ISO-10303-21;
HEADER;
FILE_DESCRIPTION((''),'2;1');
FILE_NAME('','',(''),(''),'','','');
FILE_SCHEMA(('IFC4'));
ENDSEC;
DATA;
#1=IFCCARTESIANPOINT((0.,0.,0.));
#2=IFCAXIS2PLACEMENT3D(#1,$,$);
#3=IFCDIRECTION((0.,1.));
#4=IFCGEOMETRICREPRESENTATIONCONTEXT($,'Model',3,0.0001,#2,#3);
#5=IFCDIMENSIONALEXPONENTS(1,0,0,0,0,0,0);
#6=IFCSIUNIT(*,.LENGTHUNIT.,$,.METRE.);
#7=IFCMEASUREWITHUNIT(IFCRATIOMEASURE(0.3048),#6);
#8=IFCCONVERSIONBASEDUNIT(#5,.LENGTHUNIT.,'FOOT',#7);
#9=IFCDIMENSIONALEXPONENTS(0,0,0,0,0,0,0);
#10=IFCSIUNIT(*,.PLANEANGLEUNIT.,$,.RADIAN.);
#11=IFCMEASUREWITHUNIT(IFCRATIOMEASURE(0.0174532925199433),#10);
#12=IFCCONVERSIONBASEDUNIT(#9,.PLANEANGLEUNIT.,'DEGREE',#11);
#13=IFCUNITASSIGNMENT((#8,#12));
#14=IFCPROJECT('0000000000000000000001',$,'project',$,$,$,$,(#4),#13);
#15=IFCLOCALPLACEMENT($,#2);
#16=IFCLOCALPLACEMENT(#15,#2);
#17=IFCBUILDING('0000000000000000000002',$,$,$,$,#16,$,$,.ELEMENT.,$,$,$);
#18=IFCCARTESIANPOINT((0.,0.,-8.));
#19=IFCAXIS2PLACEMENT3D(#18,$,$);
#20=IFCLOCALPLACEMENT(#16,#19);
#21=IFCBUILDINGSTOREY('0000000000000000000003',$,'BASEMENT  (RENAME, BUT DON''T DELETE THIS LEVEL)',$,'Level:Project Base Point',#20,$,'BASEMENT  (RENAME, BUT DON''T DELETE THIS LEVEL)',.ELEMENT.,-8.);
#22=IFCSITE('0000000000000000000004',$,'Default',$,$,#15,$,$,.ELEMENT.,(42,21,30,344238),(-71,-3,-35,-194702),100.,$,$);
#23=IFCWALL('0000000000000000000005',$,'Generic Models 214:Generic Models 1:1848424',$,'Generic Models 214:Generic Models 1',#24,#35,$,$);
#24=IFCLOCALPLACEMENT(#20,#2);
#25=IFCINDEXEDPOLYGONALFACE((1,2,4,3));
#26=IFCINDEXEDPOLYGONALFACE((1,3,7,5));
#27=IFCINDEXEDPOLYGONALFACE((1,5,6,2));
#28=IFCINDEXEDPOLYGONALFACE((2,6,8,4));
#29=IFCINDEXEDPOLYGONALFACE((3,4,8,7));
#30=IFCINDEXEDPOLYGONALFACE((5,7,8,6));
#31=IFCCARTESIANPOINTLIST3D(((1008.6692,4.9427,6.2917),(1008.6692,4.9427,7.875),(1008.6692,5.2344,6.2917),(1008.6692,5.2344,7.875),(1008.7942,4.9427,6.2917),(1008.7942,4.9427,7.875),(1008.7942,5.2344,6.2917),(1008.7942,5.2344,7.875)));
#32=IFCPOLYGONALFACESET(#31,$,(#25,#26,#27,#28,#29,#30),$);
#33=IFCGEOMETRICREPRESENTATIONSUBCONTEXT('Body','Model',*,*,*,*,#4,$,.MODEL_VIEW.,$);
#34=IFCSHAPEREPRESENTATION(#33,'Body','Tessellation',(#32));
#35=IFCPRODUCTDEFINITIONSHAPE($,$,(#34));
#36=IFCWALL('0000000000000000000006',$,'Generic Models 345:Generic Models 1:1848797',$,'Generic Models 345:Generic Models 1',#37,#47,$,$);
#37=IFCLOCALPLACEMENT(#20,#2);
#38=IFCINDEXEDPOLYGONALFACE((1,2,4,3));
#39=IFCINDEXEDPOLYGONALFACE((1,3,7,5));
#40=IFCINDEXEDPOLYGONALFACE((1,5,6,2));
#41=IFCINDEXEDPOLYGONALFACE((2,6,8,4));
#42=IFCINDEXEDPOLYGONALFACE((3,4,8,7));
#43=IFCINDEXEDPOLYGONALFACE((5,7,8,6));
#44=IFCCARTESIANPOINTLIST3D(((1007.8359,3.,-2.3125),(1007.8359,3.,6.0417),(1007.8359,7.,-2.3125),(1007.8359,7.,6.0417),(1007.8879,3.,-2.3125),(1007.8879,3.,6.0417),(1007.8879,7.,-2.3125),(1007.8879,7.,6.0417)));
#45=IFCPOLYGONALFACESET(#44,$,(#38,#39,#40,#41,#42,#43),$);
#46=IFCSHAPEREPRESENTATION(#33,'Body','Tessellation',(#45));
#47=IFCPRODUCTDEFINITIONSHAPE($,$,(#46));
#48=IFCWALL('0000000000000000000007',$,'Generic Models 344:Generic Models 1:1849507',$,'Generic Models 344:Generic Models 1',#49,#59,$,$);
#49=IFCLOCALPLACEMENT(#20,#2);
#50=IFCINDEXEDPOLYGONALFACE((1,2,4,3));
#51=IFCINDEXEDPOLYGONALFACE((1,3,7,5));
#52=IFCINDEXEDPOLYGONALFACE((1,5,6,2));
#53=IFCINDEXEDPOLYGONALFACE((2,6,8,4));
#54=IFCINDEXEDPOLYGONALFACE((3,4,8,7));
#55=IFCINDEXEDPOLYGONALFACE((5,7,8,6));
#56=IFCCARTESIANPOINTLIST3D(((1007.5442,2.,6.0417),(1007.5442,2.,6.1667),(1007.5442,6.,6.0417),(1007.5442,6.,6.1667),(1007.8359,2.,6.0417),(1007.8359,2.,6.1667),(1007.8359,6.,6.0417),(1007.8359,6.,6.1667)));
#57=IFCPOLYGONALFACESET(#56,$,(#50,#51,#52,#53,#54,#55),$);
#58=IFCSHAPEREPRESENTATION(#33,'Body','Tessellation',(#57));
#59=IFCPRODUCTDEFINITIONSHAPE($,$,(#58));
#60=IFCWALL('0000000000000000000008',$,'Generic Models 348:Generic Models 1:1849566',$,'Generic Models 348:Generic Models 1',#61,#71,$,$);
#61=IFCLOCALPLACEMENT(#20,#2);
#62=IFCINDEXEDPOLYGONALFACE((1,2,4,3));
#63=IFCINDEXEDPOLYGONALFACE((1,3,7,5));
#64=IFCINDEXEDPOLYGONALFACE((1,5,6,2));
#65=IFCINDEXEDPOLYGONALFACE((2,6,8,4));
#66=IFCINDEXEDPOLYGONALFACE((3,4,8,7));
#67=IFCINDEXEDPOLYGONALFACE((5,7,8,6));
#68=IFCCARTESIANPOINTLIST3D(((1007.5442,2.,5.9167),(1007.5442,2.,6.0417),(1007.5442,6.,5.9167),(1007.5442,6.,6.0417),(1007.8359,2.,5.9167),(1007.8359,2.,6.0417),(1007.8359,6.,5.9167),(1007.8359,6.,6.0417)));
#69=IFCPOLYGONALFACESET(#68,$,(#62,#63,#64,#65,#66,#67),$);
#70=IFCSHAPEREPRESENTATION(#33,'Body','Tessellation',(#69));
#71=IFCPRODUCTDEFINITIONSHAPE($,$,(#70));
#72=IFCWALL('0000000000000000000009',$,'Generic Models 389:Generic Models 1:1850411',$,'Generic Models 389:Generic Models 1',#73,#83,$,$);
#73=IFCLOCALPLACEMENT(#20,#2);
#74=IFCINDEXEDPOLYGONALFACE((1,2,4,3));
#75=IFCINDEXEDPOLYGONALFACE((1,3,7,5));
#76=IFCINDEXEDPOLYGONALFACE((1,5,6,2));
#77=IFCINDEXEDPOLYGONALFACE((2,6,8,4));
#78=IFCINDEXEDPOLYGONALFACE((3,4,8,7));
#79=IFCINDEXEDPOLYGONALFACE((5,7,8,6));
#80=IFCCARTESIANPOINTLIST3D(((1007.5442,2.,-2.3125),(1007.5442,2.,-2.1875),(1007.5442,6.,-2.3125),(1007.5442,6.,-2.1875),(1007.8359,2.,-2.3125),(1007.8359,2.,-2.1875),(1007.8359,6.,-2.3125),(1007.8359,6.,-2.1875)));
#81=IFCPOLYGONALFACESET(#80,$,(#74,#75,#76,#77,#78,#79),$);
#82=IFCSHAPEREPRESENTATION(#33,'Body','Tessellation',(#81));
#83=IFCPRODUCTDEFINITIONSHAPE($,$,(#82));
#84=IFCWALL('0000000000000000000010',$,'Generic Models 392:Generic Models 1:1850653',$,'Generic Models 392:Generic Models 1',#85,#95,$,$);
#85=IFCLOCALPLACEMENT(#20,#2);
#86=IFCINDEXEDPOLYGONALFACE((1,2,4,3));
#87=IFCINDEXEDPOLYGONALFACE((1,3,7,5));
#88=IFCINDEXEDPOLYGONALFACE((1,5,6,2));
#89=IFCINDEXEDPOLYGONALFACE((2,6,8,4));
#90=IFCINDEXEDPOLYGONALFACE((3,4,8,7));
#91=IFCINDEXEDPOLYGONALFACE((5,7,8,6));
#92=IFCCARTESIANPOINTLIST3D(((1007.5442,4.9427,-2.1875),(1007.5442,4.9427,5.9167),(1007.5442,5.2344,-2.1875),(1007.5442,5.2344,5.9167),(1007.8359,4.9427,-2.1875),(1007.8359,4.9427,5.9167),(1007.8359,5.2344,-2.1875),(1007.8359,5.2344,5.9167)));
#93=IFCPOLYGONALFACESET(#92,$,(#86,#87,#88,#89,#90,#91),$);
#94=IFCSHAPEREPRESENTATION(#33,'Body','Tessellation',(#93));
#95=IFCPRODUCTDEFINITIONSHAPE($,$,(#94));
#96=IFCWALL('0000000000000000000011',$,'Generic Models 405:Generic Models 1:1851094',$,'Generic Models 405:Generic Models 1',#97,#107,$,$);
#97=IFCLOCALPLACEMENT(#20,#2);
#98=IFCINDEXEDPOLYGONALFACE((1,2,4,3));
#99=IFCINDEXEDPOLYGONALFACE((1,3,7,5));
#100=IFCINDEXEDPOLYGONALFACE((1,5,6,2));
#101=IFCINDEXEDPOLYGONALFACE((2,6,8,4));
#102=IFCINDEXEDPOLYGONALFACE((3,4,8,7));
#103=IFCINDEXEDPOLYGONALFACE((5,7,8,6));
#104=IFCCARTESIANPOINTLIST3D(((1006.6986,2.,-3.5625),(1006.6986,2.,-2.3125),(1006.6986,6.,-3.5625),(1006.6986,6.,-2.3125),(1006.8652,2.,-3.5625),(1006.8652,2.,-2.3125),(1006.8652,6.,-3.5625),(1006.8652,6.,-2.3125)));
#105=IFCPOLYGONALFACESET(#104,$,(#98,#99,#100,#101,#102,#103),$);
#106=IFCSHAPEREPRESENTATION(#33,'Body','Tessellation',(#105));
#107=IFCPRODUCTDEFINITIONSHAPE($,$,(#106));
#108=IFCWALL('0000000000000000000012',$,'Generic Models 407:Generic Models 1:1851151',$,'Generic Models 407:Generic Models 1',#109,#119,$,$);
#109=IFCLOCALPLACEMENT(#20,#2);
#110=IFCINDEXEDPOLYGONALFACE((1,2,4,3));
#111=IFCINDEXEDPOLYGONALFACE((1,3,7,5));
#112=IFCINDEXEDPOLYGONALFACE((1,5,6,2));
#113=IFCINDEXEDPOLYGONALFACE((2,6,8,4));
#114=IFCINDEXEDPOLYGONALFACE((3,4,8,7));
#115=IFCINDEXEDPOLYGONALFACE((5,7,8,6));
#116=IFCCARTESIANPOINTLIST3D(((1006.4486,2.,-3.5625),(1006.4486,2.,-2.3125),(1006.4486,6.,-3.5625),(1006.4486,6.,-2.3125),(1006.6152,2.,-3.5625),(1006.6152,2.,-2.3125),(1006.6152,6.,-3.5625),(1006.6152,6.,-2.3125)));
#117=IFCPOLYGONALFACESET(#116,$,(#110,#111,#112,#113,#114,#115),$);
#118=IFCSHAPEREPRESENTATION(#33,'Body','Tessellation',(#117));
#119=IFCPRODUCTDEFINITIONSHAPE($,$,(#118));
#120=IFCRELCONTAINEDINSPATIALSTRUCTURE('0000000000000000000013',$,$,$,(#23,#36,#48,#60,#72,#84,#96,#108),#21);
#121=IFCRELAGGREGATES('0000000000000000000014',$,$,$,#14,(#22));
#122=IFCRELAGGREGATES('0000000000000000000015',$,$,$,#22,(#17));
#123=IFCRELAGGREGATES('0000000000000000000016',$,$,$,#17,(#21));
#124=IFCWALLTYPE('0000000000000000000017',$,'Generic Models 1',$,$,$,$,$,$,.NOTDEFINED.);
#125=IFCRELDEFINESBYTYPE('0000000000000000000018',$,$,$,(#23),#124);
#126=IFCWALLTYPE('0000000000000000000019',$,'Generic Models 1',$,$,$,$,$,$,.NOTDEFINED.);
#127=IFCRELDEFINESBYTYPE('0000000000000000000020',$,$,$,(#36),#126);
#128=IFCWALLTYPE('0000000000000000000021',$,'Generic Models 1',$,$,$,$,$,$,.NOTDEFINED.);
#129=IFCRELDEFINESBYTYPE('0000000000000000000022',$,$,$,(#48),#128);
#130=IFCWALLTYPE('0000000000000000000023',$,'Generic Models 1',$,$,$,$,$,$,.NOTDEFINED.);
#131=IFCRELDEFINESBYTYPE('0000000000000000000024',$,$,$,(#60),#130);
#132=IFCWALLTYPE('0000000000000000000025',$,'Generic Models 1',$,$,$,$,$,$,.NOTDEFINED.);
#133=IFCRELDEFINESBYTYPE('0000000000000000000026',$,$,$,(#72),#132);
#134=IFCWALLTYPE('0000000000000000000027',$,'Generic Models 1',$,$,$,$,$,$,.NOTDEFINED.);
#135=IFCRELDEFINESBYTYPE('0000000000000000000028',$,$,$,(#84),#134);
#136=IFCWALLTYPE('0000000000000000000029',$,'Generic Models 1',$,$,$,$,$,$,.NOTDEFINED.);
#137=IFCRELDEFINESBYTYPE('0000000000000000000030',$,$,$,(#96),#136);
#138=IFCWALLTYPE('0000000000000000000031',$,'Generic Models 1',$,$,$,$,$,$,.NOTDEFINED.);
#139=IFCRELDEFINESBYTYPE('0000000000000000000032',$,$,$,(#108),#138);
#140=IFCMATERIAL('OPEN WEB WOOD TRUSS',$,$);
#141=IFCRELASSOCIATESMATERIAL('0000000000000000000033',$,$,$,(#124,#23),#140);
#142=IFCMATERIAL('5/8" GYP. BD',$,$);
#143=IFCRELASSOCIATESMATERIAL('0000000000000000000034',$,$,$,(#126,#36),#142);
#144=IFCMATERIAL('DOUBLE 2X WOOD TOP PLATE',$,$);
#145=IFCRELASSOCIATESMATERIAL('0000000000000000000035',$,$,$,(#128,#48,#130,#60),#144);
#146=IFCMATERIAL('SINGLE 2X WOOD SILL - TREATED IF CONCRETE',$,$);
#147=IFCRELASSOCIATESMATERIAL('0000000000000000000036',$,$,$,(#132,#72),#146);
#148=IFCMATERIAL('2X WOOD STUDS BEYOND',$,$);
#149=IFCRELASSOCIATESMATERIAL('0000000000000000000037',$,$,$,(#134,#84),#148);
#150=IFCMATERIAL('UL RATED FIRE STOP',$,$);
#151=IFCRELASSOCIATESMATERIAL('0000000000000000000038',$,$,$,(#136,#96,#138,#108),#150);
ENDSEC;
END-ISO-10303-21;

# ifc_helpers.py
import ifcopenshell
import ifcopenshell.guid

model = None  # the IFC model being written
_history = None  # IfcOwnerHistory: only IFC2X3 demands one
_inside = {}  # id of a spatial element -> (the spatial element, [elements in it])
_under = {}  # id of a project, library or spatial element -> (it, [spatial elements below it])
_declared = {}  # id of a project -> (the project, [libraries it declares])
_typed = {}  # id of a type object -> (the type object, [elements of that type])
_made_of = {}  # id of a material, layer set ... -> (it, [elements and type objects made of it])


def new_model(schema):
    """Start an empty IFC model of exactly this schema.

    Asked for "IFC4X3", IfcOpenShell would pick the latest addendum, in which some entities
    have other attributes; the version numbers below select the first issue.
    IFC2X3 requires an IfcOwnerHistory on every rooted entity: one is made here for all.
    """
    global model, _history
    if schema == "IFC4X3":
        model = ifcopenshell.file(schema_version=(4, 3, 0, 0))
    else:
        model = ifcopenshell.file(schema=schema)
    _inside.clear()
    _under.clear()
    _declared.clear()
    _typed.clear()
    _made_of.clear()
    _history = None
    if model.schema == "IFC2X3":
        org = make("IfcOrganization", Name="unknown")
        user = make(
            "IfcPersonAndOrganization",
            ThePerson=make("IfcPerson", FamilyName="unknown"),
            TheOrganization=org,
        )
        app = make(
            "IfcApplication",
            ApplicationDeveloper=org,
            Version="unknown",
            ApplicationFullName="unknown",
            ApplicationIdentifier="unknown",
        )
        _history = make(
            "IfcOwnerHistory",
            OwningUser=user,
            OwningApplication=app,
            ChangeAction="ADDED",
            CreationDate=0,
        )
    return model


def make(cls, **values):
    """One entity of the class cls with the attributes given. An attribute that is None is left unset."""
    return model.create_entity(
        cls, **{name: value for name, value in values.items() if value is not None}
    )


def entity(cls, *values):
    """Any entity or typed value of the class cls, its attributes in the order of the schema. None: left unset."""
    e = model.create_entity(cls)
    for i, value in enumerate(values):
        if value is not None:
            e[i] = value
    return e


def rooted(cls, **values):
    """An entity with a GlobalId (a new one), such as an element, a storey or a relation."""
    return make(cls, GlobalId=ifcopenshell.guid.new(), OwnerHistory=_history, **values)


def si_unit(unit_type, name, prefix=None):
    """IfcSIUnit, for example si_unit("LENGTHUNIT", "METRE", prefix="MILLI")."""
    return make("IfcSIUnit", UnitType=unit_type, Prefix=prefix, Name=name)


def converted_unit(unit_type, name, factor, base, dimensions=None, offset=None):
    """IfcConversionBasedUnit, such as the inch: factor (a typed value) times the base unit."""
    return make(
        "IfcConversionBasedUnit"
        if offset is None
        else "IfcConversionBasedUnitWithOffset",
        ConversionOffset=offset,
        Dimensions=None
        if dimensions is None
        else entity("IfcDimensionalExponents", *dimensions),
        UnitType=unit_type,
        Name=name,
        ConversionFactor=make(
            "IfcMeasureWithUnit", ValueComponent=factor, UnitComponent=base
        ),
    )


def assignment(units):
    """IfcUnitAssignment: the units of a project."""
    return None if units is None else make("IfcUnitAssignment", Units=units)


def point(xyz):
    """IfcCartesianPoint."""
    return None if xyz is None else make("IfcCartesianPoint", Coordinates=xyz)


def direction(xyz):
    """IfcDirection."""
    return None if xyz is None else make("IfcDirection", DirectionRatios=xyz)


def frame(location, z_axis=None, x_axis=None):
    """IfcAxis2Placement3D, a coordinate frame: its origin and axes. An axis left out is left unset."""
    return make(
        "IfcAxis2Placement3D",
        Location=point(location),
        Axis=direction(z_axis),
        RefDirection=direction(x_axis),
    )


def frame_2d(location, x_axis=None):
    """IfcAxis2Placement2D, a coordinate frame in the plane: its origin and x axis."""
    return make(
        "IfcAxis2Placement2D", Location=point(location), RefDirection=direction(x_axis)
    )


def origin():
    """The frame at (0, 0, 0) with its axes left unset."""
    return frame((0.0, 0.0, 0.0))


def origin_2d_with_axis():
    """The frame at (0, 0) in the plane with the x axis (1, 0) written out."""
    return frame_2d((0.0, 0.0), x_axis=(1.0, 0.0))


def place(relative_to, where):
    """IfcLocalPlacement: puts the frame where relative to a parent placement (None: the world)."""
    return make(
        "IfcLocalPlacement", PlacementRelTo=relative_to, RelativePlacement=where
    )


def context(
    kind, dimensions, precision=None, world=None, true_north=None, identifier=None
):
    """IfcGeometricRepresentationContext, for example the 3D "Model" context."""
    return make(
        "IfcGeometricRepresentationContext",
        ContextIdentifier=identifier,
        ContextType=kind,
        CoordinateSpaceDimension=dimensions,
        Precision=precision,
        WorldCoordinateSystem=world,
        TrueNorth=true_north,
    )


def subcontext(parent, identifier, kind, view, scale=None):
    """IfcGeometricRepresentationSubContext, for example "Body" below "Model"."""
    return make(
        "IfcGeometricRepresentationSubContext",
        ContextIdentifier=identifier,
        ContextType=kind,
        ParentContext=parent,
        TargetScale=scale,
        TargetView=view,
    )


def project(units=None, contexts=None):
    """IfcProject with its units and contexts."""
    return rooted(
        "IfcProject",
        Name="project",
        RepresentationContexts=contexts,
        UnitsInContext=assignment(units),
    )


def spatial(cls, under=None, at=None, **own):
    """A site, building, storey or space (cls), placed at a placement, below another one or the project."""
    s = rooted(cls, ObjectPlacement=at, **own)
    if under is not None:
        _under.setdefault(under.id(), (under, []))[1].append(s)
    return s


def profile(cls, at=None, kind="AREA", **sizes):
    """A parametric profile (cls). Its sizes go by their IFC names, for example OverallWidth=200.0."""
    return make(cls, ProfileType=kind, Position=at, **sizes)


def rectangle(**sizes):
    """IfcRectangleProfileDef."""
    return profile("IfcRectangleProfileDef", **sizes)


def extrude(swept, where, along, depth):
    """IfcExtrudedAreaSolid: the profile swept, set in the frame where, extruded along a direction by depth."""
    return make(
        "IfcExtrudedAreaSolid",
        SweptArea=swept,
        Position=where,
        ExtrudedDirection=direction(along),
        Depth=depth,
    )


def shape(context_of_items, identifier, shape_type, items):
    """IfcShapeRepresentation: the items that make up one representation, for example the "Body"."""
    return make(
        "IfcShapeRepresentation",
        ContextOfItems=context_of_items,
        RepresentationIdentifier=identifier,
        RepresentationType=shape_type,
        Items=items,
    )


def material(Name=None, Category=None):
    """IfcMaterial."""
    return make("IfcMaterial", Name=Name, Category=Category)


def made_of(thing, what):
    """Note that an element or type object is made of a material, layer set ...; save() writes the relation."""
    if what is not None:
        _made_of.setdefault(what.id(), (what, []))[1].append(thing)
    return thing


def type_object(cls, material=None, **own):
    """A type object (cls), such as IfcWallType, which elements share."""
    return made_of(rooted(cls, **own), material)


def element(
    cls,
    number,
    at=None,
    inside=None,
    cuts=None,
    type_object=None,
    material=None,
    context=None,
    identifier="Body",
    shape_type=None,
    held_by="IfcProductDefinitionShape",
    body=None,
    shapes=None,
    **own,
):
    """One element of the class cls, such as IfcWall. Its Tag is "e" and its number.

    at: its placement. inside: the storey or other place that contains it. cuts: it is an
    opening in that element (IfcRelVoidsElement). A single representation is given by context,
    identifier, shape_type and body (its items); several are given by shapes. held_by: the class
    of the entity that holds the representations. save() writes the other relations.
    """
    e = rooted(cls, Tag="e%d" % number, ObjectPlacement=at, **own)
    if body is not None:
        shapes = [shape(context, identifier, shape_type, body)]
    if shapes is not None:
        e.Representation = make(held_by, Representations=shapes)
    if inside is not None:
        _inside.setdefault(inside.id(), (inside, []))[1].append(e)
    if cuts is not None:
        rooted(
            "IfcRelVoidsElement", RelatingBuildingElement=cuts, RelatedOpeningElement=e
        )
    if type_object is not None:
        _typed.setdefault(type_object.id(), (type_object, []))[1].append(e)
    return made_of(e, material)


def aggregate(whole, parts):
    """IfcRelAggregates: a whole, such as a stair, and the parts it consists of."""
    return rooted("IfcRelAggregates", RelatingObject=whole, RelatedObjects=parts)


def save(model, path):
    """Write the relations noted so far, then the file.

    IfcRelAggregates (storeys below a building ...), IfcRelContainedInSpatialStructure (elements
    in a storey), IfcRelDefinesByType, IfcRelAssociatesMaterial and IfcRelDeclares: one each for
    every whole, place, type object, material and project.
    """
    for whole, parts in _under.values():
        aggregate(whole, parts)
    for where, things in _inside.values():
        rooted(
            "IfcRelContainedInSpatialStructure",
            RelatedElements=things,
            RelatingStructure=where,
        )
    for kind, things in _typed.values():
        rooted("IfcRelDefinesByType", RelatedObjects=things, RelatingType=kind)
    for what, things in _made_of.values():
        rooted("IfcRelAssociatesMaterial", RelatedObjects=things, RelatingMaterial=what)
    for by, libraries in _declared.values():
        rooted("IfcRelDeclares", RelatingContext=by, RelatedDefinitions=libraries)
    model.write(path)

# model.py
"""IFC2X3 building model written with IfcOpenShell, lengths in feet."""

from ifc_helpers import new_model, entity, si_unit, converted_unit, direction, frame, frame_2d, origin, origin_2d_with_axis, place, context, subcontext, project, spatial, rectangle, extrude, material, type_object, element, save


model = new_model("IFC2X3")

# Units and contexts
model_context = context("Model", 3, precision=0.0001, world=origin(), true_north=direction((0.0, 1.0)))
body_context = subcontext(model_context, "Body", "Model", "MODEL_VIEW")
ifc_project = project(units=[converted_unit("LENGTHUNIT", "FOOT", entity("IfcRatioMeasure", 0.3048), si_unit("LENGTHUNIT", "METRE"), dimensions=[1, 0, 0, 0, 0, 0, 0]), converted_unit("PLANEANGLEUNIT", "DEGREE", entity("IfcRatioMeasure", 0.0174532925199433), si_unit("PLANEANGLEUNIT", "RADIAN"), dimensions=[0, 0, 0, 0, 0, 0, 0])], contexts=[model_context])

# Site, building, storey
site_placement = place(None, origin())
site = spatial("IfcSite", under=ifc_project, at=site_placement, Name="Default", CompositionType="ELEMENT", RefLatitude=(42, 21, 30, 344238), RefLongitude=(-71, -3, -35, -194702), RefElevation=100.0)
building_placement = place(site_placement, origin())
building = spatial("IfcBuilding", under=site, at=building_placement, CompositionType="ELEMENT")
storey_placement = place(building_placement, frame((0.0, 0.0, -8.0)))
storey = spatial("IfcBuildingStorey", under=building, at=storey_placement, Name="BASEMENT  (RENAME, BUT DON'T DELETE THIS LEVEL)", ObjectType="Level:Project Base Point", LongName="BASEMENT  (RENAME, BUT DON'T DELETE THIS LEVEL)", CompositionType="ELEMENT", Elevation=-8.0)

# Walls
ifc_material_1 = material(Name="OPEN WEB WOOD TRUSS")
wall_type_1 = type_object("IfcWallType", Name="Generic Models 1", PredefinedType="NOTDEFINED", material=ifc_material_1)
wall_1_placement = place(storey_placement, frame((1008.6692, 4.9427, 6.2917), z_axis=(0.0, 0.0, 1.0), x_axis=(0.0, 1.0, 0.0)))
element("IfcWall", 1, at=wall_1_placement, inside=storey, type_object=wall_type_1, material=ifc_material_1, Name="Generic Models 214:Generic Models 1:1848424", ObjectType="Generic Models 214:Generic Models 1", context=body_context, shape_type="SweptSolid", body=[
    extrude(rectangle(XDim=0.2917, YDim=0.125, at=frame_2d((0.0, 0.0), x_axis=(1.0, 0.0))), frame((0.1458, -0.0625, 0.0)), (0.0, 0.0, 1.0), 1.5833),
])
ifc_material_2 = material(Name="5/8\" GYP. BD")
wall_type_2 = type_object("IfcWallType", Name="Generic Models 1", PredefinedType="NOTDEFINED", material=ifc_material_2)
wall_2_placement = place(storey_placement, frame((1007.8359, 3.0, -2.3125), z_axis=(0.0, 0.0, 1.0), x_axis=(0.0, 1.0, 0.0)))
element("IfcWall", 2, at=wall_2_placement, inside=storey, type_object=wall_type_2, material=ifc_material_2, Name="Generic Models 345:Generic Models 1:1848797", ObjectType="Generic Models 345:Generic Models 1", context=body_context, shape_type="SweptSolid", body=[
    extrude(rectangle(XDim=4.0, YDim=0.0521, at=frame_2d((0.0, 0.0), x_axis=(1.0, 0.0))), frame((2.0, -0.026, 0.0)), (0.0, 0.0, 1.0), 8.3542),
])
ifc_material_3 = material(Name="DOUBLE 2X WOOD TOP PLATE")
wall_type_3 = type_object("IfcWallType", Name="Generic Models 1", PredefinedType="NOTDEFINED", material=ifc_material_3)
wall_3_placement = place(storey_placement, frame((1007.5442, 2.0, 6.0417), z_axis=(0.0, 0.0, 1.0), x_axis=(0.0, 1.0, 0.0)))
element("IfcWall", 3, at=wall_3_placement, inside=storey, type_object=wall_type_3, material=ifc_material_3, Name="Generic Models 344:Generic Models 1:1849507", ObjectType="Generic Models 344:Generic Models 1", context=body_context, shape_type="SweptSolid", body=[
    extrude(rectangle(XDim=4.0, YDim=0.2917, at=frame_2d((0.0, 0.0), x_axis=(1.0, 0.0))), frame((2.0, -0.1458, 0.0)), (0.0, 0.0, 1.0), 0.125),
])
wall_type_4 = type_object("IfcWallType", Name="Generic Models 1", PredefinedType="NOTDEFINED", material=ifc_material_3)
wall_4_placement = place(storey_placement, frame((1007.5442, 2.0, 5.9167), z_axis=(0.0, 0.0, 1.0), x_axis=(0.0, 1.0, 0.0)))
element("IfcWall", 4, at=wall_4_placement, inside=storey, type_object=wall_type_4, material=ifc_material_3, Name="Generic Models 348:Generic Models 1:1849566", ObjectType="Generic Models 348:Generic Models 1", context=body_context, shape_type="SweptSolid", body=[
    extrude(rectangle(XDim=4.0, YDim=0.2917, at=frame_2d((0.0, 0.0), x_axis=(1.0, 0.0))), frame((2.0, -0.1458, 0.0)), (0.0, 0.0, 1.0), 0.125),
])
ifc_material_4 = material(Name="SINGLE 2X WOOD SILL - TREATED IF CONCRETE")
wall_type_5 = type_object("IfcWallType", Name="Generic Models 1", PredefinedType="NOTDEFINED", material=ifc_material_4)
wall_5_placement = place(storey_placement, frame((1007.5442, 2.0, -2.3125), z_axis=(0.0, 0.0, 1.0), x_axis=(0.0, 1.0, 0.0)))
element("IfcWall", 5, at=wall_5_placement, inside=storey, type_object=wall_type_5, material=ifc_material_4, Name="Generic Models 389:Generic Models 1:1850411", ObjectType="Generic Models 389:Generic Models 1", context=body_context, shape_type="SweptSolid", body=[
    extrude(rectangle(XDim=4.0, YDim=0.2917, at=frame_2d((0.0, 0.0), x_axis=(1.0, 0.0))), frame((2.0, -0.1458, 0.0)), (0.0, 0.0, 1.0), 0.125),
])
ifc_material_5 = material(Name="2X WOOD STUDS BEYOND")
wall_type_6 = type_object("IfcWallType", Name="Generic Models 1", PredefinedType="NOTDEFINED", material=ifc_material_5)
wall_6_placement = place(storey_placement, frame((1007.5442, 4.9427, -2.1875)))
element("IfcWall", 6, at=wall_6_placement, inside=storey, type_object=wall_type_6, material=ifc_material_5, Name="Generic Models 392:Generic Models 1:1850653", ObjectType="Generic Models 392:Generic Models 1", context=body_context, shape_type="SweptSolid", body=[
    extrude(rectangle(XDim=0.2917, YDim=0.2917, at=origin_2d_with_axis()), frame((0.1458, 0.1458, 0.0), z_axis=(0.0, 0.0, 1.0), x_axis=(0.0, 1.0, 0.0)), (0.0, 0.0, 1.0), 8.1042),
])
ifc_material_6 = material(Name="UL RATED FIRE STOP")
wall_type_7 = type_object("IfcWallType", Name="Generic Models 1", PredefinedType="NOTDEFINED", material=ifc_material_6)
wall_7_placement = place(storey_placement, frame((1006.6986, 2.0, -3.5625), z_axis=(0.0, 0.0, 1.0), x_axis=(0.0, 1.0, 0.0)))
element("IfcWall", 7, at=wall_7_placement, inside=storey, type_object=wall_type_7, material=ifc_material_6, Name="Generic Models 405:Generic Models 1:1851094", ObjectType="Generic Models 405:Generic Models 1", context=body_context, shape_type="SweptSolid", body=[
    extrude(rectangle(XDim=4.0, YDim=0.1667, at=frame_2d((0.0, 0.0), x_axis=(1.0, 0.0))), frame((2.0, -0.0833, 0.0)), (0.0, 0.0, 1.0), 1.25),
])
wall_type_8 = type_object("IfcWallType", Name="Generic Models 1", PredefinedType="NOTDEFINED", material=ifc_material_6)
wall_8_placement = place(storey_placement, frame((1006.4486, 2.0, -3.5625), z_axis=(0.0, 0.0, 1.0), x_axis=(0.0, 1.0, 0.0)))
element("IfcWall", 8, at=wall_8_placement, inside=storey, type_object=wall_type_8, material=ifc_material_6, Name="Generic Models 407:Generic Models 1:1851151", ObjectType="Generic Models 407:Generic Models 1", context=body_context, shape_type="SweptSolid", body=[
    extrude(rectangle(XDim=4.0, YDim=0.1667, at=frame_2d((0.0, 0.0), x_axis=(1.0, 0.0))), frame((2.0, -0.0833, 0.0)), (0.0, 0.0, 1.0), 1.25),
])

save(model, "model.ifc")
